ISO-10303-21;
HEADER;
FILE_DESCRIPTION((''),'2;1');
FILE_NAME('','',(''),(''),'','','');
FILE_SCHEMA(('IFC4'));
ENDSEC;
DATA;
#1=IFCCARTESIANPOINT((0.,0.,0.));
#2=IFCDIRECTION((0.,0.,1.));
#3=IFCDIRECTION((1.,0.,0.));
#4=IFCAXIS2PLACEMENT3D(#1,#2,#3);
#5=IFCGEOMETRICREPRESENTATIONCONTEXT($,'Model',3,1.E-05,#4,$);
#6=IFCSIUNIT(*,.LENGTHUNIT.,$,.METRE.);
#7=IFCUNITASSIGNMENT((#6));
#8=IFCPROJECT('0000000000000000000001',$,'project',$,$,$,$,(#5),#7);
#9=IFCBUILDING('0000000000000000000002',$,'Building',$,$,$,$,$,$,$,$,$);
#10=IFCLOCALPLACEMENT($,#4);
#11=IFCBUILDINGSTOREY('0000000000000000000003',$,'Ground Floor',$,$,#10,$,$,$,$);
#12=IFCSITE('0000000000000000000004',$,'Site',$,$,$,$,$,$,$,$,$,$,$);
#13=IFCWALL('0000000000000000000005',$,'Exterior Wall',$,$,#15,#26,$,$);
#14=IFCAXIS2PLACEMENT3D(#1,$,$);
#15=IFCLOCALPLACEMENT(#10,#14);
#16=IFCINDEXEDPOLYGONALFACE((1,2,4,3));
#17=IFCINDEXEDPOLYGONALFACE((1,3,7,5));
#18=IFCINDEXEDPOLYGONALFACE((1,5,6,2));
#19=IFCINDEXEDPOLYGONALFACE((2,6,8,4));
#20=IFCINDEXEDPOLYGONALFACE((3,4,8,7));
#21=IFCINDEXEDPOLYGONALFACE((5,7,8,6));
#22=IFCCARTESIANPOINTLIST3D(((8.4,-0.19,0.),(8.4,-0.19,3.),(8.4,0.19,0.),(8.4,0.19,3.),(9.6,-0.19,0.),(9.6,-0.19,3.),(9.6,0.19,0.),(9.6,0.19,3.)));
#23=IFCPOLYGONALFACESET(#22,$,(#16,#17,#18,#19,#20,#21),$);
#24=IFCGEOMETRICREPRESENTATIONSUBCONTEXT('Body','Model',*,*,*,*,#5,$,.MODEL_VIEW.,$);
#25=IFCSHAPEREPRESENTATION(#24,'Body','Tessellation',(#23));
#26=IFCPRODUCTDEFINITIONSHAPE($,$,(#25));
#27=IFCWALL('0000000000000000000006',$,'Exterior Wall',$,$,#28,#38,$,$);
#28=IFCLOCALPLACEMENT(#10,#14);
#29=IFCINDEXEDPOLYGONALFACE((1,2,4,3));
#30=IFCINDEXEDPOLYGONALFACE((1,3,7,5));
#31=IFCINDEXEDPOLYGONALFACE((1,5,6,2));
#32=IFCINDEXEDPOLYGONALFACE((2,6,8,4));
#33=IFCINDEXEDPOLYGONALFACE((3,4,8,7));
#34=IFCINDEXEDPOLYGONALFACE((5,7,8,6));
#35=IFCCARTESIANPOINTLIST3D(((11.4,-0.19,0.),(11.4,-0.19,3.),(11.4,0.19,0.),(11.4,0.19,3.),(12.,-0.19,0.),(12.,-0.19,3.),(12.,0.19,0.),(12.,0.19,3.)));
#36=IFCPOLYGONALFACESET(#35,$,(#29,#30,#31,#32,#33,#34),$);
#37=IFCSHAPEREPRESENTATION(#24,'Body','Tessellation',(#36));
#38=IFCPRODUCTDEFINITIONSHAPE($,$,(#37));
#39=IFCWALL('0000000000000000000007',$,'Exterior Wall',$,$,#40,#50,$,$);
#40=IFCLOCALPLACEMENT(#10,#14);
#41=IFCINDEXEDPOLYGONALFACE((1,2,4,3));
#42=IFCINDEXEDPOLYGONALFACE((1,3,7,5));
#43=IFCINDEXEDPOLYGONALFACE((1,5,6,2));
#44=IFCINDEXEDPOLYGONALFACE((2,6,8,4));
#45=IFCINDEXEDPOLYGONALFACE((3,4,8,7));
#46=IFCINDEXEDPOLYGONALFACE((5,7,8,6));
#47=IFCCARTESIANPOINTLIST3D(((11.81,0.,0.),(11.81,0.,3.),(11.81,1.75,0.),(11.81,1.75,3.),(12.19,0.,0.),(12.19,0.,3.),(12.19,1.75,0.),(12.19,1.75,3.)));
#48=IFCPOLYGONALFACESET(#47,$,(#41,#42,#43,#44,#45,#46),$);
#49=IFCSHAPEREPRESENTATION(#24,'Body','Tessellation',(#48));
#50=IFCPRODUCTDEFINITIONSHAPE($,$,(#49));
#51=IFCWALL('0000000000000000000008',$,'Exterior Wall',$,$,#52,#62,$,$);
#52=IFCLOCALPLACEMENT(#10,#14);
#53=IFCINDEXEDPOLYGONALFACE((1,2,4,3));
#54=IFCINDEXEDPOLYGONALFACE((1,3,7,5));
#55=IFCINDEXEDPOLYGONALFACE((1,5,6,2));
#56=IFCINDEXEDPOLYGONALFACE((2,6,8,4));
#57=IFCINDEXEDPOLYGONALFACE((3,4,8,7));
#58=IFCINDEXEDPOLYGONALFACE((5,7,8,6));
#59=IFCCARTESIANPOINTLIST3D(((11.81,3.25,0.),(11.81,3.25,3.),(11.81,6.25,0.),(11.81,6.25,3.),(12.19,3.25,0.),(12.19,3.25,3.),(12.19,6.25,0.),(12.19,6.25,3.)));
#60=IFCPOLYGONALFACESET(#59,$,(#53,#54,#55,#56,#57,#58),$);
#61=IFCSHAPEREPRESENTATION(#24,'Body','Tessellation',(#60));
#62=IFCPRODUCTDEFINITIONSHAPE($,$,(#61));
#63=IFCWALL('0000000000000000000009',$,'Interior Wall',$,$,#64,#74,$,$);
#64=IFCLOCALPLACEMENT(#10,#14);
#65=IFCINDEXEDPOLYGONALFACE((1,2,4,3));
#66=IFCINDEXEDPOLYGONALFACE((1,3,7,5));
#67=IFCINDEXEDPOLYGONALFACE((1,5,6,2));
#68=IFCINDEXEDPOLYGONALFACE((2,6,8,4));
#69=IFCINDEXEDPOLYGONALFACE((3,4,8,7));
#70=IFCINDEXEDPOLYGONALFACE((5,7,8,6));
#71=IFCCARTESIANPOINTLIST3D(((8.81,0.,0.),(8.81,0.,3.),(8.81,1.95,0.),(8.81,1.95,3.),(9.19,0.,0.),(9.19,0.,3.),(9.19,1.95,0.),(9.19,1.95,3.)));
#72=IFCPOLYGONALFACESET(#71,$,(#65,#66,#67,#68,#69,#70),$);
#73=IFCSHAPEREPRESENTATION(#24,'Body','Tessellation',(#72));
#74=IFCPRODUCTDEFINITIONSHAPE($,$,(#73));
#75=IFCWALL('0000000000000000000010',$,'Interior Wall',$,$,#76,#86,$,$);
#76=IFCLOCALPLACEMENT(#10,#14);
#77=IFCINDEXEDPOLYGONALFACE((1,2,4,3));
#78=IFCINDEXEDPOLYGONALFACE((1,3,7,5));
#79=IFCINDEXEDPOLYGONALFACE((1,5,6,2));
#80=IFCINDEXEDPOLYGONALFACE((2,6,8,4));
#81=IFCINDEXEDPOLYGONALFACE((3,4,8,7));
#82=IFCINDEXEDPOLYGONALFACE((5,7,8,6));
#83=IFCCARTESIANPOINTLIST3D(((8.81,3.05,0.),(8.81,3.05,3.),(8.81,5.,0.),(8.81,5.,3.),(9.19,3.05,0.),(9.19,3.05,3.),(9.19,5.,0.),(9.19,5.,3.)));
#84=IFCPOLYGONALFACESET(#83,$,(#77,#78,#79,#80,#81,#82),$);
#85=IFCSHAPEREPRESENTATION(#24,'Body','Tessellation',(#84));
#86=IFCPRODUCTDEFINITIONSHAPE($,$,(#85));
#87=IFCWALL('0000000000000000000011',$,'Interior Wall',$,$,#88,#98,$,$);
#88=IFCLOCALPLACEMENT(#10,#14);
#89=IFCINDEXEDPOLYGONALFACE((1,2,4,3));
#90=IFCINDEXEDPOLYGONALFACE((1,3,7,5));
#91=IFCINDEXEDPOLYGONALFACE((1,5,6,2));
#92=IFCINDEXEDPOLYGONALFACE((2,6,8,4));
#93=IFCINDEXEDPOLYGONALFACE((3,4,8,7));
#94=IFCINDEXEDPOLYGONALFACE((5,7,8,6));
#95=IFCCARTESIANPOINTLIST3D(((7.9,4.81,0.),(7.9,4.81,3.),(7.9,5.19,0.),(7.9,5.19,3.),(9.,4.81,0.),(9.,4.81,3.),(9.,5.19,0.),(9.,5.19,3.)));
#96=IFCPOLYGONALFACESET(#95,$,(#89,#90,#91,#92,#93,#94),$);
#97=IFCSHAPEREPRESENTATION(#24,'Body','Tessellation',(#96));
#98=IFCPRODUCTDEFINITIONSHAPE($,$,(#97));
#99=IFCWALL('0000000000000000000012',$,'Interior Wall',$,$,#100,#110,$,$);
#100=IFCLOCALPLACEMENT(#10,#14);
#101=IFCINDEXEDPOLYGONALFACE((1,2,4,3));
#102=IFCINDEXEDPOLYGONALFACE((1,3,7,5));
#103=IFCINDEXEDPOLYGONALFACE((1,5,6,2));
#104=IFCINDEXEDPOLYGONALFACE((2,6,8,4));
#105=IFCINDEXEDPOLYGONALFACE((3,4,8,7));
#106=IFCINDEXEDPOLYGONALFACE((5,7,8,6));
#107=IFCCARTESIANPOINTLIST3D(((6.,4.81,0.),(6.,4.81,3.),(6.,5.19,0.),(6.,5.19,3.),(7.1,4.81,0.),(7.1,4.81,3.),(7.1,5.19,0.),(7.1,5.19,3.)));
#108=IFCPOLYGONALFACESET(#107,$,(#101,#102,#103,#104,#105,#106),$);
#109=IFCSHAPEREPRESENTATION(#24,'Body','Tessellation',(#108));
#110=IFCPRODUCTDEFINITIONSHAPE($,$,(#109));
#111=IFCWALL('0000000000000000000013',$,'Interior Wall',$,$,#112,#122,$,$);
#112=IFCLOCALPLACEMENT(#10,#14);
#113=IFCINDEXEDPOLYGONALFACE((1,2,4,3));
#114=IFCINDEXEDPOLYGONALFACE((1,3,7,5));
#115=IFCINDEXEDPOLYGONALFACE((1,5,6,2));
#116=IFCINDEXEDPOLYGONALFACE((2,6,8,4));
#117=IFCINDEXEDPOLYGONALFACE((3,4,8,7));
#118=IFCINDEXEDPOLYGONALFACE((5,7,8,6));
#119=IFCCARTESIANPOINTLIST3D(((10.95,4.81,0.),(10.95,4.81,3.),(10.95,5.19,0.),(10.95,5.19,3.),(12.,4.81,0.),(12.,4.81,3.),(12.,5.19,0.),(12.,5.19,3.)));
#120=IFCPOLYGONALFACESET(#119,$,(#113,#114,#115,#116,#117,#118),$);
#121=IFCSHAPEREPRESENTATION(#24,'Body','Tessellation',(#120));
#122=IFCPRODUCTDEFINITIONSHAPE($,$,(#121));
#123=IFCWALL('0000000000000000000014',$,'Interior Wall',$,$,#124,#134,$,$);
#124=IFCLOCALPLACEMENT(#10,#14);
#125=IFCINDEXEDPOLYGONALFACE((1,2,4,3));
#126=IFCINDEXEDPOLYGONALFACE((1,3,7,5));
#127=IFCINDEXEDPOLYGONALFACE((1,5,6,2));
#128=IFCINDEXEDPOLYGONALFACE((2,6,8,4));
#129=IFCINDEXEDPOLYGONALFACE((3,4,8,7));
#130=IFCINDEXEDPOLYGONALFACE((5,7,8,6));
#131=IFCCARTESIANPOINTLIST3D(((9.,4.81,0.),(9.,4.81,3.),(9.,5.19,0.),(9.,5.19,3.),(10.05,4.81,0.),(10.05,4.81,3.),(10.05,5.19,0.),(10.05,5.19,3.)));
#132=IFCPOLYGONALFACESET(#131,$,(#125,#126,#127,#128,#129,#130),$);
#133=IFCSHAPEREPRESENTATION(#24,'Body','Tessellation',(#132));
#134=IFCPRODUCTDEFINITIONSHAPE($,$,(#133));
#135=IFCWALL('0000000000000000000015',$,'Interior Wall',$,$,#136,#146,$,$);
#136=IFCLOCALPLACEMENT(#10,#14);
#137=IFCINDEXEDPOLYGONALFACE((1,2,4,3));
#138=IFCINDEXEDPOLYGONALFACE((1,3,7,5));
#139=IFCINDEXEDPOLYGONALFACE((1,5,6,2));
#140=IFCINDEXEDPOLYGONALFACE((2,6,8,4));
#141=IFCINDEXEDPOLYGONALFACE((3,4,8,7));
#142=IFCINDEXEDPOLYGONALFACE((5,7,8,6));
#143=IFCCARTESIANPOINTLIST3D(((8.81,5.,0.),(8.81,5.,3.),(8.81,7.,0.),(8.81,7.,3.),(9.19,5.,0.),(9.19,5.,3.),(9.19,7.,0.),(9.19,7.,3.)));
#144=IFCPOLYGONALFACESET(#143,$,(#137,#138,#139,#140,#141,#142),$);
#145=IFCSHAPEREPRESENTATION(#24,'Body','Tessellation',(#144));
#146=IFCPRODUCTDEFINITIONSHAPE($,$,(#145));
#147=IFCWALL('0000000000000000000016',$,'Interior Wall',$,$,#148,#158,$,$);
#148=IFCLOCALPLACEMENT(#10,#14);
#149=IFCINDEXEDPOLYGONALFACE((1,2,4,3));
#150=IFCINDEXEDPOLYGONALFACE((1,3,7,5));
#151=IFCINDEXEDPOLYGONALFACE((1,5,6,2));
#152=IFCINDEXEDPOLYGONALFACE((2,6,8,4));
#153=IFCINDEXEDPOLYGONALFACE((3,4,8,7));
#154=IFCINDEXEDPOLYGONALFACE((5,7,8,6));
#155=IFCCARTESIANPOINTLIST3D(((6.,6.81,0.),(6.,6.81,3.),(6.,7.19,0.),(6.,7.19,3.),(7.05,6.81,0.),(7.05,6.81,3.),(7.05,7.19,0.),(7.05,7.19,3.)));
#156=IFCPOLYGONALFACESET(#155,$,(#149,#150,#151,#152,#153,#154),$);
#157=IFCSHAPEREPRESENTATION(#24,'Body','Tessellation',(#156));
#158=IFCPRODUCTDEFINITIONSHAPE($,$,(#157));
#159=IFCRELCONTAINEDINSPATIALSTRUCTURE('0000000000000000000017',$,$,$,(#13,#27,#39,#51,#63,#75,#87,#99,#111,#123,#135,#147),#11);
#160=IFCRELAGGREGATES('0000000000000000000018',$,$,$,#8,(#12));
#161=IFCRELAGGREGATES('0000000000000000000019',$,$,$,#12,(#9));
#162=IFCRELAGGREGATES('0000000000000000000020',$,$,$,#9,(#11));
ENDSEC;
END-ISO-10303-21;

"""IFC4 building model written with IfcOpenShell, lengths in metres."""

from ifc_helpers import new_model, si_unit, frame, origin_with_axes, place, context, subcontext, project, spatial, indexed_curve, outline, extrude, element, save


model = new_model("IFC4")

# Units and contexts
model_context = context("Model", 3, precision=1e-05, world=origin_with_axes())
body_context = subcontext(model_context, "Body", "Model", "MODEL_VIEW")
ifc_project = project(units=[si_unit("LENGTHUNIT", "METRE")], contexts=[model_context])

# Site, building, storey
site = spatial("IfcSite", under=ifc_project, Name="Site")
building = spatial("IfcBuilding", under=site, Name="Building")
storey_placement = place(None, origin_with_axes())
storey = spatial("IfcBuildingStorey", under=building, at=storey_placement, Name="Ground Floor")

# Walls
wall_1_placement = place(storey_placement, frame((8.4, 0.0, 0.0), z_axis=(0.0, 0.0, 1.0), x_axis=(1.0, 0.0, 0.0)))
element("IfcWall", 1, at=wall_1_placement, inside=storey, Name="Exterior Wall", context=body_context, shape_type="SweptSolid", body=[
    extrude(outline(indexed_curve([(0.0, 0.0), (0.0, 0.38), (1.2, 0.38), (1.2, 0.0), (0.0, 0.0)], self_intersect=False)), frame((0.0, -0.19, 0.0), z_axis=(0.0, 0.0, 1.0), x_axis=(1.0, 0.0, 0.0)), (0.0, 0.0, 1.0), 3.0),
])
wall_2_placement = place(storey_placement, frame((11.4, 0.0, 0.0), z_axis=(0.0, 0.0, 1.0), x_axis=(1.0, 0.0, 0.0)))
element("IfcWall", 2, at=wall_2_placement, inside=storey, Name="Exterior Wall", context=body_context, shape_type="SweptSolid", body=[
    extrude(outline(indexed_curve([(0.0, 0.0), (0.0, 0.38), (0.6, 0.38), (0.6, 0.0), (0.0, 0.0)], self_intersect=False)), frame((0.0, -0.19, 0.0), z_axis=(0.0, 0.0, 1.0), x_axis=(1.0, 0.0, 0.0)), (0.0, 0.0, 1.0), 3.0),
])
wall_3_placement = place(storey_placement, frame((12.0, 0.0, 0.0), z_axis=(0.0, 0.0, 1.0), x_axis=(0.0, 1.0, 0.0)))
element("IfcWall", 3, at=wall_3_placement, inside=storey, Name="Exterior Wall", context=body_context, shape_type="SweptSolid", body=[
    extrude(outline(indexed_curve([(0.0, 0.0), (0.0, 0.38), (1.75, 0.38), (1.75, 0.0), (0.0, 0.0)], self_intersect=False)), frame((0.0, -0.19, 0.0), z_axis=(0.0, 0.0, 1.0), x_axis=(1.0, 0.0, 0.0)), (0.0, 0.0, 1.0), 3.0),
])
wall_4_placement = place(storey_placement, frame((12.0, 3.25, 0.0), z_axis=(0.0, 0.0, 1.0), x_axis=(0.0, 1.0, 0.0)))
element("IfcWall", 4, at=wall_4_placement, inside=storey, Name="Exterior Wall", context=body_context, shape_type="SweptSolid", body=[
    extrude(outline(indexed_curve([(0.0, 0.0), (0.0, 0.38), (3.0, 0.38), (3.0, 0.0), (0.0, 0.0)], self_intersect=False)), frame((0.0, -0.19, 0.0), z_axis=(0.0, 0.0, 1.0), x_axis=(1.0, 0.0, 0.0)), (0.0, 0.0, 1.0), 3.0),
])
wall_5_placement = place(storey_placement, frame((9.0, 0.0, 0.0), z_axis=(0.0, 0.0, 1.0), x_axis=(0.0, 1.0, 0.0)))
element("IfcWall", 5, at=wall_5_placement, inside=storey, Name="Interior Wall", context=body_context, shape_type="SweptSolid", body=[
    extrude(outline(indexed_curve([(0.0, 0.0), (0.0, 0.38), (1.95, 0.38), (1.95, 0.0), (0.0, 0.0)], self_intersect=False)), frame((0.0, -0.19, 0.0), z_axis=(0.0, 0.0, 1.0), x_axis=(1.0, 0.0, 0.0)), (0.0, 0.0, 1.0), 3.0),
])
wall_6_placement = place(storey_placement, frame((9.0, 3.05, 0.0), z_axis=(0.0, 0.0, 1.0), x_axis=(0.0, 1.0, 0.0)))
element("IfcWall", 6, at=wall_6_placement, inside=storey, Name="Interior Wall", context=body_context, shape_type="SweptSolid", body=[
    extrude(outline(indexed_curve([(0.0, 0.0), (0.0, 0.38), (1.95, 0.38), (1.95, 0.0), (0.0, 0.0)], self_intersect=False)), frame((0.0, -0.19, 0.0), z_axis=(0.0, 0.0, 1.0), x_axis=(1.0, 0.0, 0.0)), (0.0, 0.0, 1.0), 3.0),
])
for number, where, z_axis, x_axis, name in (
    (7, (9.0, 5.0, 0.0), (0.0, 0.0, 1.0), (-1.0, 0.0, 0.0), "Interior Wall"),
    (8, (7.1, 5.0, 0.0), (0.0, 0.0, 1.0), (-1.0, 0.0, 0.0), "Interior Wall"),
):
    element("IfcWall", number, at=place(storey_placement, frame(where, z_axis=z_axis, x_axis=x_axis)), inside=storey, Name=name, context=body_context, shape_type="SweptSolid", body=[
        extrude(outline(indexed_curve([(0.0, 0.0), (0.0, 0.38), (1.1, 0.38), (1.1, 0.0), (0.0, 0.0)], self_intersect=False)), frame((0.0, -0.19, 0.0), z_axis=(0.0, 0.0, 1.0), x_axis=(1.0, 0.0, 0.0)), (0.0, 0.0, 1.0), 3.0),
    ])
for number, where, z_axis, x_axis, name in (
    (9, (12.0, 5.0, 0.0), (0.0, 0.0, 1.0), (-1.0, 0.0, 0.0), "Interior Wall"),
    (10, (10.05, 5.0, 0.0), (0.0, 0.0, 1.0), (-1.0, 0.0, 0.0), "Interior Wall"),
):
    element("IfcWall", number, at=place(storey_placement, frame(where, z_axis=z_axis, x_axis=x_axis)), inside=storey, Name=name, context=body_context, shape_type="SweptSolid", body=[
        extrude(outline(indexed_curve([(0.0, 0.0), (0.0, 0.38), (1.05, 0.38), (1.05, 0.0), (0.0, 0.0)], self_intersect=False)), frame((0.0, -0.19, 0.0), z_axis=(0.0, 0.0, 1.0), x_axis=(1.0, 0.0, 0.0)), (0.0, 0.0, 1.0), 3.0),
    ])
wall_7_placement = place(storey_placement, frame((9.0, 5.0, 0.0), z_axis=(0.0, 0.0, 1.0), x_axis=(0.0, 1.0, 0.0)))
element("IfcWall", 11, at=wall_7_placement, inside=storey, Name="Interior Wall", context=body_context, shape_type="SweptSolid", body=[
    extrude(outline(indexed_curve([(0.0, 0.0), (0.0, 0.38), (2.0, 0.38), (2.0, 0.0), (0.0, 0.0)], self_intersect=False)), frame((0.0, -0.19, 0.0), z_axis=(0.0, 0.0, 1.0), x_axis=(1.0, 0.0, 0.0)), (0.0, 0.0, 1.0), 3.0),
])
wall_8_placement = place(storey_placement, frame((7.05, 7.0, 0.0), z_axis=(0.0, 0.0, 1.0), x_axis=(-1.0, 0.0, 0.0)))
element("IfcWall", 12, at=wall_8_placement, inside=storey, Name="Interior Wall", context=body_context, shape_type="SweptSolid", body=[
    extrude(outline(indexed_curve([(0.0, 0.0), (0.0, 0.38), (1.05, 0.38), (1.05, 0.0), (0.0, 0.0)], self_intersect=False)), frame((0.0, -0.19, 0.0), z_axis=(0.0, 0.0, 1.0), x_axis=(1.0, 0.0, 0.0)), (0.0, 0.0, 1.0), 3.0),
])

save(model, "model.ifc")
